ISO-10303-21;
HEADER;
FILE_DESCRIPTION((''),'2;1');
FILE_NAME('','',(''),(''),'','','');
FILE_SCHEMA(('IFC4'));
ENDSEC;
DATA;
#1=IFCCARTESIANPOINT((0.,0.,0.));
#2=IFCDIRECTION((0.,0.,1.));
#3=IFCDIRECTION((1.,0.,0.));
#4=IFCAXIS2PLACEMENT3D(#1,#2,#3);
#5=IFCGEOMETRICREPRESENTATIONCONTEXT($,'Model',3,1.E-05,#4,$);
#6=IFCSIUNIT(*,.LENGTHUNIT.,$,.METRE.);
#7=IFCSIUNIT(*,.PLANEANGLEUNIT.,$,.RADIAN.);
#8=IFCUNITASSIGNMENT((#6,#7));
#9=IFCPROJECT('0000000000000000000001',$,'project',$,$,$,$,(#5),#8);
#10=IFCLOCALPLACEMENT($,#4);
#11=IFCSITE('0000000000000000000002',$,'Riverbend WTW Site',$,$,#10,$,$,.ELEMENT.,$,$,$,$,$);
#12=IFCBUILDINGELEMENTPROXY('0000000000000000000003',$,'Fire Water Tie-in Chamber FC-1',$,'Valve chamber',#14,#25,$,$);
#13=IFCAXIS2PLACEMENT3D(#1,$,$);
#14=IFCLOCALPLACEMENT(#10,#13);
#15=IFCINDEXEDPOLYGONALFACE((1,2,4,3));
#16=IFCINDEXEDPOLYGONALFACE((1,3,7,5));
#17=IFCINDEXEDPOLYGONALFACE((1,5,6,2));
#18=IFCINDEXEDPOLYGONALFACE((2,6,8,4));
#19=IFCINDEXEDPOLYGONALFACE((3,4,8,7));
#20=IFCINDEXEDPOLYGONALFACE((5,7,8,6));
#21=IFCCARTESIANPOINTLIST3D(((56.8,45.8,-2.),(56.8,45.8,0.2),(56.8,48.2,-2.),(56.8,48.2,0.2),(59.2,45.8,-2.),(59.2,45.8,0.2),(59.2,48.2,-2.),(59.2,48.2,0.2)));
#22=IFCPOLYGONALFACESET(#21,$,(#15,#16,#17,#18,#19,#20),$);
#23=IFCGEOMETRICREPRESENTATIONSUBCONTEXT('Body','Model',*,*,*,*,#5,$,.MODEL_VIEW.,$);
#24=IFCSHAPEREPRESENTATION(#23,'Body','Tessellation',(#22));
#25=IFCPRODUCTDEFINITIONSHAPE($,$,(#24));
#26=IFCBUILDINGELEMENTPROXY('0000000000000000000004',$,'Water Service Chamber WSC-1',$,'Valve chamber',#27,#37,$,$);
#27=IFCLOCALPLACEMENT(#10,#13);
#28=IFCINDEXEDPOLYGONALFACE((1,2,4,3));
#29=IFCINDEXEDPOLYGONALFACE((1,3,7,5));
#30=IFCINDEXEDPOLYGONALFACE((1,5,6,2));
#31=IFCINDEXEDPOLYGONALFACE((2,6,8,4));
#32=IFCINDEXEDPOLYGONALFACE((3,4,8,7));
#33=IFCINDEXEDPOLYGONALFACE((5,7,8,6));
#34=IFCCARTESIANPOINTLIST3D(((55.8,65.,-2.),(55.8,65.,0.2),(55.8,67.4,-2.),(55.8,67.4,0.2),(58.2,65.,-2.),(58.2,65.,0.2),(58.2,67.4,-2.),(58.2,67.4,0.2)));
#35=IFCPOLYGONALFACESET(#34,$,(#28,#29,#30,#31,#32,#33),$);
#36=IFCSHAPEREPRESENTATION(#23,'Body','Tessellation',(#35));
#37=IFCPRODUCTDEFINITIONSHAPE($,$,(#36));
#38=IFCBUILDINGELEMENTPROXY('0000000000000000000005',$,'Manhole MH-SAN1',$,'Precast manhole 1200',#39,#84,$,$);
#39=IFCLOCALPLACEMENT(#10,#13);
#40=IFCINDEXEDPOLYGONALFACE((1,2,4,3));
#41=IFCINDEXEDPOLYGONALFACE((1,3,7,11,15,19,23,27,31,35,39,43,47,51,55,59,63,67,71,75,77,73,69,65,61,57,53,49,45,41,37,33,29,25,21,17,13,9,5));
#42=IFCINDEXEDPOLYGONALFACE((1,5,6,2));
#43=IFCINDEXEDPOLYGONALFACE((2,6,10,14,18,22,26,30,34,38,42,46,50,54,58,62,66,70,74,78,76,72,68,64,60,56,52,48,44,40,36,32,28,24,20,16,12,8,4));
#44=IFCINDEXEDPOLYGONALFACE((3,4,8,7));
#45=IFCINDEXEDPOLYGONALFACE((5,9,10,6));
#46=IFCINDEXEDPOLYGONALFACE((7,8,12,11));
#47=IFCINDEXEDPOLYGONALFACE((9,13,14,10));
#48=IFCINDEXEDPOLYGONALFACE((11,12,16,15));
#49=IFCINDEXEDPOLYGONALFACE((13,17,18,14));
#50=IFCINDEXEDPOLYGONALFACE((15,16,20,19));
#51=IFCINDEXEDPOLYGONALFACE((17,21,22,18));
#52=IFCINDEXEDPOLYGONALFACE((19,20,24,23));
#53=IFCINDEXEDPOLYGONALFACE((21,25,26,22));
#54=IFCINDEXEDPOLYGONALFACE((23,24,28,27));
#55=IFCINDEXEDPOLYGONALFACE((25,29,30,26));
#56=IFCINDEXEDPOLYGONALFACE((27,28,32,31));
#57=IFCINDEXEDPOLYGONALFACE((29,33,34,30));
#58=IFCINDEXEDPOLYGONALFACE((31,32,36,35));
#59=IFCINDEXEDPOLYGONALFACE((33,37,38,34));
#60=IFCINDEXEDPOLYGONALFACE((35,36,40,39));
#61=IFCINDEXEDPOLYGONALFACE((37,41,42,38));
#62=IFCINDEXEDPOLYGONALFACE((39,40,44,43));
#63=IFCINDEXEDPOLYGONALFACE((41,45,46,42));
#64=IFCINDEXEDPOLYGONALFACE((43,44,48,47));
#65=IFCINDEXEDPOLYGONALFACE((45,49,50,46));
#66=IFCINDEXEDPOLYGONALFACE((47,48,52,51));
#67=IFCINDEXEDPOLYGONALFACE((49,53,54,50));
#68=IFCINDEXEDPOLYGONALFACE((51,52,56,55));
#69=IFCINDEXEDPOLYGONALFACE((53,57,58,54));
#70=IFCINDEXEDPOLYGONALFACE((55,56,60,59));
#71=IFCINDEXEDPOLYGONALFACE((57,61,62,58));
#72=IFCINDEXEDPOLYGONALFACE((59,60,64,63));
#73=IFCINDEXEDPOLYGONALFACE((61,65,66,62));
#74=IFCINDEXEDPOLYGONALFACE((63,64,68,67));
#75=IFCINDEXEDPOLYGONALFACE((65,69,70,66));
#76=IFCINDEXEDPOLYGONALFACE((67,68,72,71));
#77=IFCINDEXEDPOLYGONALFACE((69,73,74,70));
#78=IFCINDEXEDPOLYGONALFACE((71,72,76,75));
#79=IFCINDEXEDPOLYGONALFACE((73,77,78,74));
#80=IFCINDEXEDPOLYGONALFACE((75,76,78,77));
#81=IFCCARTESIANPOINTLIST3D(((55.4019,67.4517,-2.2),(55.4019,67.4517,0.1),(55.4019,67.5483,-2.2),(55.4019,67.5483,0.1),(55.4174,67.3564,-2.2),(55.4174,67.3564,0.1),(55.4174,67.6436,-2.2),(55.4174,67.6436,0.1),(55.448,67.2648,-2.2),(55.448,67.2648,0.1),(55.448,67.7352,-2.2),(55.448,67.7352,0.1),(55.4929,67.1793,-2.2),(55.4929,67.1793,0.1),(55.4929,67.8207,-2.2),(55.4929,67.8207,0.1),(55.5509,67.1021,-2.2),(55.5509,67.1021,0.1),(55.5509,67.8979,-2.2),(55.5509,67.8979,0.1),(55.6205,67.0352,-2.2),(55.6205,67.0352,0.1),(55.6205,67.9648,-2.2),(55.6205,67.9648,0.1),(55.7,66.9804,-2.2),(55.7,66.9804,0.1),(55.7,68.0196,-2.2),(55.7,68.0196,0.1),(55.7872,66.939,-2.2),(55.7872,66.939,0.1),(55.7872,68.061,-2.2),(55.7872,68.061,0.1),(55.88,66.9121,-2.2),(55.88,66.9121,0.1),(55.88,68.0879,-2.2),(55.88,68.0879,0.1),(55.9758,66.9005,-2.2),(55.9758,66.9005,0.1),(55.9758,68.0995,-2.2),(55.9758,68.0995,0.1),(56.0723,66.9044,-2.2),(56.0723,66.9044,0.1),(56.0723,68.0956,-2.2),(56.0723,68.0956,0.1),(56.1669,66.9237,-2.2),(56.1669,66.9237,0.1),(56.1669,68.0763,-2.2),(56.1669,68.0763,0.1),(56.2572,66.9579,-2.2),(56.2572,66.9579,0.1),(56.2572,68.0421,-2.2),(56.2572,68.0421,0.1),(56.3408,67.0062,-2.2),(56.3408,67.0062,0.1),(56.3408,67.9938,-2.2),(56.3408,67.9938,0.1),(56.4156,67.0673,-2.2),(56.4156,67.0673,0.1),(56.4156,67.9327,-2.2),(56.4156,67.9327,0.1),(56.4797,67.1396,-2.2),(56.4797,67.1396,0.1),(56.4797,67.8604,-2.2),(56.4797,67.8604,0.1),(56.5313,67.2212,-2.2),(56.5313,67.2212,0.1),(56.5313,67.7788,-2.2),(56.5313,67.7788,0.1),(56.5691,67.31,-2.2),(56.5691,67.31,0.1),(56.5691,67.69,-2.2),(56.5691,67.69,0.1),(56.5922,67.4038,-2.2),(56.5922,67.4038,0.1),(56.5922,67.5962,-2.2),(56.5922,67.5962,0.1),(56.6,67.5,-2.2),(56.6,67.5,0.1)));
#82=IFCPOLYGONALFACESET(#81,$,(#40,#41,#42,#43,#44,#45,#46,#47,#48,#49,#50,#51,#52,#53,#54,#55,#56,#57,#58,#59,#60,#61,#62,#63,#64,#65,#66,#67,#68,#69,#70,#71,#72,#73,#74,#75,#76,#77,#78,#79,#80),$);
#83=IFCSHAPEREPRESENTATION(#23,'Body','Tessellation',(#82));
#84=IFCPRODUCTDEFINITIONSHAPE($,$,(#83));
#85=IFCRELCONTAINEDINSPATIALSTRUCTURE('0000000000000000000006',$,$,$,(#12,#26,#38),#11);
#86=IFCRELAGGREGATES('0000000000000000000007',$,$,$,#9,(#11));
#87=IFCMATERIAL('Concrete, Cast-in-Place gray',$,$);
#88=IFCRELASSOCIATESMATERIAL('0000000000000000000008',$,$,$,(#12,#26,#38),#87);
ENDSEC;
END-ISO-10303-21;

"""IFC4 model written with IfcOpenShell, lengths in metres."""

from ifc_helpers import new_model, si_unit, frame, origin_with_axes, origin_2d, place, context, subcontext, project, spatial, rectangle, circle, extrude, material, element, save


model = new_model("IFC4")

# Units and contexts
model_context = context("Model", 3, precision=1e-05, world=origin_with_axes())
body_context = subcontext(model_context, "Body", "Model", "MODEL_VIEW")
ifc_project = project(units=[si_unit("LENGTHUNIT", "METRE"), si_unit("PLANEANGLEUNIT", "RADIAN")], contexts=[model_context])

# Site
site_placement = place(None, origin_with_axes())
site = spatial("IfcSite", under=ifc_project, at=site_placement, Name="Riverbend WTW Site", CompositionType="ELEMENT")

# Shared definitions
ifc_material_1 = material(Name="Concrete, Cast-in-Place gray")

# Building element proxies
for number, where, z_axis, x_axis, name in (
    (1, (58.0, 47.0, -0.9), (0.0, 0.0, 1.0), (1.0, 0.0, 0.0), "Fire Water Tie-in Chamber FC-1"),
    (2, (57.0, 66.2, -0.9), (0.0, 0.0, 1.0), (1.0, 0.0, 0.0), "Water Service Chamber WSC-1"),
):
    element("IfcBuildingElementProxy", number, at=place(None, frame(where, z_axis=z_axis, x_axis=x_axis)), inside=site, material=ifc_material_1, Name=name, ObjectType="Valve chamber", context=body_context, shape_type="SweptSolid", body=[
        extrude(rectangle(XDim=2.4, YDim=2.4, at=origin_2d()), frame((0.0, 0.0, -1.1), z_axis=(0.0, 0.0, 1.0), x_axis=(1.0, 0.0, 0.0)), (0.0, 0.0, 1.0), 2.2),
    ])
proxy_1_placement = place(None, frame((56.0, 67.5, -2.2), z_axis=(0.0, 0.0, 1.0), x_axis=(1.0, 0.0, 0.0)))
element("IfcBuildingElementProxy", 3, at=proxy_1_placement, inside=site, material=ifc_material_1, Name="Manhole MH-SAN1", ObjectType="Precast manhole 1200", context=body_context, shape_type="SweptSolid", body=[
    extrude(circle(Radius=0.6, at=origin_2d()), origin_with_axes(), (0.0, 0.0, 1.0), 2.3),
])

save(model, "model.ifc")
